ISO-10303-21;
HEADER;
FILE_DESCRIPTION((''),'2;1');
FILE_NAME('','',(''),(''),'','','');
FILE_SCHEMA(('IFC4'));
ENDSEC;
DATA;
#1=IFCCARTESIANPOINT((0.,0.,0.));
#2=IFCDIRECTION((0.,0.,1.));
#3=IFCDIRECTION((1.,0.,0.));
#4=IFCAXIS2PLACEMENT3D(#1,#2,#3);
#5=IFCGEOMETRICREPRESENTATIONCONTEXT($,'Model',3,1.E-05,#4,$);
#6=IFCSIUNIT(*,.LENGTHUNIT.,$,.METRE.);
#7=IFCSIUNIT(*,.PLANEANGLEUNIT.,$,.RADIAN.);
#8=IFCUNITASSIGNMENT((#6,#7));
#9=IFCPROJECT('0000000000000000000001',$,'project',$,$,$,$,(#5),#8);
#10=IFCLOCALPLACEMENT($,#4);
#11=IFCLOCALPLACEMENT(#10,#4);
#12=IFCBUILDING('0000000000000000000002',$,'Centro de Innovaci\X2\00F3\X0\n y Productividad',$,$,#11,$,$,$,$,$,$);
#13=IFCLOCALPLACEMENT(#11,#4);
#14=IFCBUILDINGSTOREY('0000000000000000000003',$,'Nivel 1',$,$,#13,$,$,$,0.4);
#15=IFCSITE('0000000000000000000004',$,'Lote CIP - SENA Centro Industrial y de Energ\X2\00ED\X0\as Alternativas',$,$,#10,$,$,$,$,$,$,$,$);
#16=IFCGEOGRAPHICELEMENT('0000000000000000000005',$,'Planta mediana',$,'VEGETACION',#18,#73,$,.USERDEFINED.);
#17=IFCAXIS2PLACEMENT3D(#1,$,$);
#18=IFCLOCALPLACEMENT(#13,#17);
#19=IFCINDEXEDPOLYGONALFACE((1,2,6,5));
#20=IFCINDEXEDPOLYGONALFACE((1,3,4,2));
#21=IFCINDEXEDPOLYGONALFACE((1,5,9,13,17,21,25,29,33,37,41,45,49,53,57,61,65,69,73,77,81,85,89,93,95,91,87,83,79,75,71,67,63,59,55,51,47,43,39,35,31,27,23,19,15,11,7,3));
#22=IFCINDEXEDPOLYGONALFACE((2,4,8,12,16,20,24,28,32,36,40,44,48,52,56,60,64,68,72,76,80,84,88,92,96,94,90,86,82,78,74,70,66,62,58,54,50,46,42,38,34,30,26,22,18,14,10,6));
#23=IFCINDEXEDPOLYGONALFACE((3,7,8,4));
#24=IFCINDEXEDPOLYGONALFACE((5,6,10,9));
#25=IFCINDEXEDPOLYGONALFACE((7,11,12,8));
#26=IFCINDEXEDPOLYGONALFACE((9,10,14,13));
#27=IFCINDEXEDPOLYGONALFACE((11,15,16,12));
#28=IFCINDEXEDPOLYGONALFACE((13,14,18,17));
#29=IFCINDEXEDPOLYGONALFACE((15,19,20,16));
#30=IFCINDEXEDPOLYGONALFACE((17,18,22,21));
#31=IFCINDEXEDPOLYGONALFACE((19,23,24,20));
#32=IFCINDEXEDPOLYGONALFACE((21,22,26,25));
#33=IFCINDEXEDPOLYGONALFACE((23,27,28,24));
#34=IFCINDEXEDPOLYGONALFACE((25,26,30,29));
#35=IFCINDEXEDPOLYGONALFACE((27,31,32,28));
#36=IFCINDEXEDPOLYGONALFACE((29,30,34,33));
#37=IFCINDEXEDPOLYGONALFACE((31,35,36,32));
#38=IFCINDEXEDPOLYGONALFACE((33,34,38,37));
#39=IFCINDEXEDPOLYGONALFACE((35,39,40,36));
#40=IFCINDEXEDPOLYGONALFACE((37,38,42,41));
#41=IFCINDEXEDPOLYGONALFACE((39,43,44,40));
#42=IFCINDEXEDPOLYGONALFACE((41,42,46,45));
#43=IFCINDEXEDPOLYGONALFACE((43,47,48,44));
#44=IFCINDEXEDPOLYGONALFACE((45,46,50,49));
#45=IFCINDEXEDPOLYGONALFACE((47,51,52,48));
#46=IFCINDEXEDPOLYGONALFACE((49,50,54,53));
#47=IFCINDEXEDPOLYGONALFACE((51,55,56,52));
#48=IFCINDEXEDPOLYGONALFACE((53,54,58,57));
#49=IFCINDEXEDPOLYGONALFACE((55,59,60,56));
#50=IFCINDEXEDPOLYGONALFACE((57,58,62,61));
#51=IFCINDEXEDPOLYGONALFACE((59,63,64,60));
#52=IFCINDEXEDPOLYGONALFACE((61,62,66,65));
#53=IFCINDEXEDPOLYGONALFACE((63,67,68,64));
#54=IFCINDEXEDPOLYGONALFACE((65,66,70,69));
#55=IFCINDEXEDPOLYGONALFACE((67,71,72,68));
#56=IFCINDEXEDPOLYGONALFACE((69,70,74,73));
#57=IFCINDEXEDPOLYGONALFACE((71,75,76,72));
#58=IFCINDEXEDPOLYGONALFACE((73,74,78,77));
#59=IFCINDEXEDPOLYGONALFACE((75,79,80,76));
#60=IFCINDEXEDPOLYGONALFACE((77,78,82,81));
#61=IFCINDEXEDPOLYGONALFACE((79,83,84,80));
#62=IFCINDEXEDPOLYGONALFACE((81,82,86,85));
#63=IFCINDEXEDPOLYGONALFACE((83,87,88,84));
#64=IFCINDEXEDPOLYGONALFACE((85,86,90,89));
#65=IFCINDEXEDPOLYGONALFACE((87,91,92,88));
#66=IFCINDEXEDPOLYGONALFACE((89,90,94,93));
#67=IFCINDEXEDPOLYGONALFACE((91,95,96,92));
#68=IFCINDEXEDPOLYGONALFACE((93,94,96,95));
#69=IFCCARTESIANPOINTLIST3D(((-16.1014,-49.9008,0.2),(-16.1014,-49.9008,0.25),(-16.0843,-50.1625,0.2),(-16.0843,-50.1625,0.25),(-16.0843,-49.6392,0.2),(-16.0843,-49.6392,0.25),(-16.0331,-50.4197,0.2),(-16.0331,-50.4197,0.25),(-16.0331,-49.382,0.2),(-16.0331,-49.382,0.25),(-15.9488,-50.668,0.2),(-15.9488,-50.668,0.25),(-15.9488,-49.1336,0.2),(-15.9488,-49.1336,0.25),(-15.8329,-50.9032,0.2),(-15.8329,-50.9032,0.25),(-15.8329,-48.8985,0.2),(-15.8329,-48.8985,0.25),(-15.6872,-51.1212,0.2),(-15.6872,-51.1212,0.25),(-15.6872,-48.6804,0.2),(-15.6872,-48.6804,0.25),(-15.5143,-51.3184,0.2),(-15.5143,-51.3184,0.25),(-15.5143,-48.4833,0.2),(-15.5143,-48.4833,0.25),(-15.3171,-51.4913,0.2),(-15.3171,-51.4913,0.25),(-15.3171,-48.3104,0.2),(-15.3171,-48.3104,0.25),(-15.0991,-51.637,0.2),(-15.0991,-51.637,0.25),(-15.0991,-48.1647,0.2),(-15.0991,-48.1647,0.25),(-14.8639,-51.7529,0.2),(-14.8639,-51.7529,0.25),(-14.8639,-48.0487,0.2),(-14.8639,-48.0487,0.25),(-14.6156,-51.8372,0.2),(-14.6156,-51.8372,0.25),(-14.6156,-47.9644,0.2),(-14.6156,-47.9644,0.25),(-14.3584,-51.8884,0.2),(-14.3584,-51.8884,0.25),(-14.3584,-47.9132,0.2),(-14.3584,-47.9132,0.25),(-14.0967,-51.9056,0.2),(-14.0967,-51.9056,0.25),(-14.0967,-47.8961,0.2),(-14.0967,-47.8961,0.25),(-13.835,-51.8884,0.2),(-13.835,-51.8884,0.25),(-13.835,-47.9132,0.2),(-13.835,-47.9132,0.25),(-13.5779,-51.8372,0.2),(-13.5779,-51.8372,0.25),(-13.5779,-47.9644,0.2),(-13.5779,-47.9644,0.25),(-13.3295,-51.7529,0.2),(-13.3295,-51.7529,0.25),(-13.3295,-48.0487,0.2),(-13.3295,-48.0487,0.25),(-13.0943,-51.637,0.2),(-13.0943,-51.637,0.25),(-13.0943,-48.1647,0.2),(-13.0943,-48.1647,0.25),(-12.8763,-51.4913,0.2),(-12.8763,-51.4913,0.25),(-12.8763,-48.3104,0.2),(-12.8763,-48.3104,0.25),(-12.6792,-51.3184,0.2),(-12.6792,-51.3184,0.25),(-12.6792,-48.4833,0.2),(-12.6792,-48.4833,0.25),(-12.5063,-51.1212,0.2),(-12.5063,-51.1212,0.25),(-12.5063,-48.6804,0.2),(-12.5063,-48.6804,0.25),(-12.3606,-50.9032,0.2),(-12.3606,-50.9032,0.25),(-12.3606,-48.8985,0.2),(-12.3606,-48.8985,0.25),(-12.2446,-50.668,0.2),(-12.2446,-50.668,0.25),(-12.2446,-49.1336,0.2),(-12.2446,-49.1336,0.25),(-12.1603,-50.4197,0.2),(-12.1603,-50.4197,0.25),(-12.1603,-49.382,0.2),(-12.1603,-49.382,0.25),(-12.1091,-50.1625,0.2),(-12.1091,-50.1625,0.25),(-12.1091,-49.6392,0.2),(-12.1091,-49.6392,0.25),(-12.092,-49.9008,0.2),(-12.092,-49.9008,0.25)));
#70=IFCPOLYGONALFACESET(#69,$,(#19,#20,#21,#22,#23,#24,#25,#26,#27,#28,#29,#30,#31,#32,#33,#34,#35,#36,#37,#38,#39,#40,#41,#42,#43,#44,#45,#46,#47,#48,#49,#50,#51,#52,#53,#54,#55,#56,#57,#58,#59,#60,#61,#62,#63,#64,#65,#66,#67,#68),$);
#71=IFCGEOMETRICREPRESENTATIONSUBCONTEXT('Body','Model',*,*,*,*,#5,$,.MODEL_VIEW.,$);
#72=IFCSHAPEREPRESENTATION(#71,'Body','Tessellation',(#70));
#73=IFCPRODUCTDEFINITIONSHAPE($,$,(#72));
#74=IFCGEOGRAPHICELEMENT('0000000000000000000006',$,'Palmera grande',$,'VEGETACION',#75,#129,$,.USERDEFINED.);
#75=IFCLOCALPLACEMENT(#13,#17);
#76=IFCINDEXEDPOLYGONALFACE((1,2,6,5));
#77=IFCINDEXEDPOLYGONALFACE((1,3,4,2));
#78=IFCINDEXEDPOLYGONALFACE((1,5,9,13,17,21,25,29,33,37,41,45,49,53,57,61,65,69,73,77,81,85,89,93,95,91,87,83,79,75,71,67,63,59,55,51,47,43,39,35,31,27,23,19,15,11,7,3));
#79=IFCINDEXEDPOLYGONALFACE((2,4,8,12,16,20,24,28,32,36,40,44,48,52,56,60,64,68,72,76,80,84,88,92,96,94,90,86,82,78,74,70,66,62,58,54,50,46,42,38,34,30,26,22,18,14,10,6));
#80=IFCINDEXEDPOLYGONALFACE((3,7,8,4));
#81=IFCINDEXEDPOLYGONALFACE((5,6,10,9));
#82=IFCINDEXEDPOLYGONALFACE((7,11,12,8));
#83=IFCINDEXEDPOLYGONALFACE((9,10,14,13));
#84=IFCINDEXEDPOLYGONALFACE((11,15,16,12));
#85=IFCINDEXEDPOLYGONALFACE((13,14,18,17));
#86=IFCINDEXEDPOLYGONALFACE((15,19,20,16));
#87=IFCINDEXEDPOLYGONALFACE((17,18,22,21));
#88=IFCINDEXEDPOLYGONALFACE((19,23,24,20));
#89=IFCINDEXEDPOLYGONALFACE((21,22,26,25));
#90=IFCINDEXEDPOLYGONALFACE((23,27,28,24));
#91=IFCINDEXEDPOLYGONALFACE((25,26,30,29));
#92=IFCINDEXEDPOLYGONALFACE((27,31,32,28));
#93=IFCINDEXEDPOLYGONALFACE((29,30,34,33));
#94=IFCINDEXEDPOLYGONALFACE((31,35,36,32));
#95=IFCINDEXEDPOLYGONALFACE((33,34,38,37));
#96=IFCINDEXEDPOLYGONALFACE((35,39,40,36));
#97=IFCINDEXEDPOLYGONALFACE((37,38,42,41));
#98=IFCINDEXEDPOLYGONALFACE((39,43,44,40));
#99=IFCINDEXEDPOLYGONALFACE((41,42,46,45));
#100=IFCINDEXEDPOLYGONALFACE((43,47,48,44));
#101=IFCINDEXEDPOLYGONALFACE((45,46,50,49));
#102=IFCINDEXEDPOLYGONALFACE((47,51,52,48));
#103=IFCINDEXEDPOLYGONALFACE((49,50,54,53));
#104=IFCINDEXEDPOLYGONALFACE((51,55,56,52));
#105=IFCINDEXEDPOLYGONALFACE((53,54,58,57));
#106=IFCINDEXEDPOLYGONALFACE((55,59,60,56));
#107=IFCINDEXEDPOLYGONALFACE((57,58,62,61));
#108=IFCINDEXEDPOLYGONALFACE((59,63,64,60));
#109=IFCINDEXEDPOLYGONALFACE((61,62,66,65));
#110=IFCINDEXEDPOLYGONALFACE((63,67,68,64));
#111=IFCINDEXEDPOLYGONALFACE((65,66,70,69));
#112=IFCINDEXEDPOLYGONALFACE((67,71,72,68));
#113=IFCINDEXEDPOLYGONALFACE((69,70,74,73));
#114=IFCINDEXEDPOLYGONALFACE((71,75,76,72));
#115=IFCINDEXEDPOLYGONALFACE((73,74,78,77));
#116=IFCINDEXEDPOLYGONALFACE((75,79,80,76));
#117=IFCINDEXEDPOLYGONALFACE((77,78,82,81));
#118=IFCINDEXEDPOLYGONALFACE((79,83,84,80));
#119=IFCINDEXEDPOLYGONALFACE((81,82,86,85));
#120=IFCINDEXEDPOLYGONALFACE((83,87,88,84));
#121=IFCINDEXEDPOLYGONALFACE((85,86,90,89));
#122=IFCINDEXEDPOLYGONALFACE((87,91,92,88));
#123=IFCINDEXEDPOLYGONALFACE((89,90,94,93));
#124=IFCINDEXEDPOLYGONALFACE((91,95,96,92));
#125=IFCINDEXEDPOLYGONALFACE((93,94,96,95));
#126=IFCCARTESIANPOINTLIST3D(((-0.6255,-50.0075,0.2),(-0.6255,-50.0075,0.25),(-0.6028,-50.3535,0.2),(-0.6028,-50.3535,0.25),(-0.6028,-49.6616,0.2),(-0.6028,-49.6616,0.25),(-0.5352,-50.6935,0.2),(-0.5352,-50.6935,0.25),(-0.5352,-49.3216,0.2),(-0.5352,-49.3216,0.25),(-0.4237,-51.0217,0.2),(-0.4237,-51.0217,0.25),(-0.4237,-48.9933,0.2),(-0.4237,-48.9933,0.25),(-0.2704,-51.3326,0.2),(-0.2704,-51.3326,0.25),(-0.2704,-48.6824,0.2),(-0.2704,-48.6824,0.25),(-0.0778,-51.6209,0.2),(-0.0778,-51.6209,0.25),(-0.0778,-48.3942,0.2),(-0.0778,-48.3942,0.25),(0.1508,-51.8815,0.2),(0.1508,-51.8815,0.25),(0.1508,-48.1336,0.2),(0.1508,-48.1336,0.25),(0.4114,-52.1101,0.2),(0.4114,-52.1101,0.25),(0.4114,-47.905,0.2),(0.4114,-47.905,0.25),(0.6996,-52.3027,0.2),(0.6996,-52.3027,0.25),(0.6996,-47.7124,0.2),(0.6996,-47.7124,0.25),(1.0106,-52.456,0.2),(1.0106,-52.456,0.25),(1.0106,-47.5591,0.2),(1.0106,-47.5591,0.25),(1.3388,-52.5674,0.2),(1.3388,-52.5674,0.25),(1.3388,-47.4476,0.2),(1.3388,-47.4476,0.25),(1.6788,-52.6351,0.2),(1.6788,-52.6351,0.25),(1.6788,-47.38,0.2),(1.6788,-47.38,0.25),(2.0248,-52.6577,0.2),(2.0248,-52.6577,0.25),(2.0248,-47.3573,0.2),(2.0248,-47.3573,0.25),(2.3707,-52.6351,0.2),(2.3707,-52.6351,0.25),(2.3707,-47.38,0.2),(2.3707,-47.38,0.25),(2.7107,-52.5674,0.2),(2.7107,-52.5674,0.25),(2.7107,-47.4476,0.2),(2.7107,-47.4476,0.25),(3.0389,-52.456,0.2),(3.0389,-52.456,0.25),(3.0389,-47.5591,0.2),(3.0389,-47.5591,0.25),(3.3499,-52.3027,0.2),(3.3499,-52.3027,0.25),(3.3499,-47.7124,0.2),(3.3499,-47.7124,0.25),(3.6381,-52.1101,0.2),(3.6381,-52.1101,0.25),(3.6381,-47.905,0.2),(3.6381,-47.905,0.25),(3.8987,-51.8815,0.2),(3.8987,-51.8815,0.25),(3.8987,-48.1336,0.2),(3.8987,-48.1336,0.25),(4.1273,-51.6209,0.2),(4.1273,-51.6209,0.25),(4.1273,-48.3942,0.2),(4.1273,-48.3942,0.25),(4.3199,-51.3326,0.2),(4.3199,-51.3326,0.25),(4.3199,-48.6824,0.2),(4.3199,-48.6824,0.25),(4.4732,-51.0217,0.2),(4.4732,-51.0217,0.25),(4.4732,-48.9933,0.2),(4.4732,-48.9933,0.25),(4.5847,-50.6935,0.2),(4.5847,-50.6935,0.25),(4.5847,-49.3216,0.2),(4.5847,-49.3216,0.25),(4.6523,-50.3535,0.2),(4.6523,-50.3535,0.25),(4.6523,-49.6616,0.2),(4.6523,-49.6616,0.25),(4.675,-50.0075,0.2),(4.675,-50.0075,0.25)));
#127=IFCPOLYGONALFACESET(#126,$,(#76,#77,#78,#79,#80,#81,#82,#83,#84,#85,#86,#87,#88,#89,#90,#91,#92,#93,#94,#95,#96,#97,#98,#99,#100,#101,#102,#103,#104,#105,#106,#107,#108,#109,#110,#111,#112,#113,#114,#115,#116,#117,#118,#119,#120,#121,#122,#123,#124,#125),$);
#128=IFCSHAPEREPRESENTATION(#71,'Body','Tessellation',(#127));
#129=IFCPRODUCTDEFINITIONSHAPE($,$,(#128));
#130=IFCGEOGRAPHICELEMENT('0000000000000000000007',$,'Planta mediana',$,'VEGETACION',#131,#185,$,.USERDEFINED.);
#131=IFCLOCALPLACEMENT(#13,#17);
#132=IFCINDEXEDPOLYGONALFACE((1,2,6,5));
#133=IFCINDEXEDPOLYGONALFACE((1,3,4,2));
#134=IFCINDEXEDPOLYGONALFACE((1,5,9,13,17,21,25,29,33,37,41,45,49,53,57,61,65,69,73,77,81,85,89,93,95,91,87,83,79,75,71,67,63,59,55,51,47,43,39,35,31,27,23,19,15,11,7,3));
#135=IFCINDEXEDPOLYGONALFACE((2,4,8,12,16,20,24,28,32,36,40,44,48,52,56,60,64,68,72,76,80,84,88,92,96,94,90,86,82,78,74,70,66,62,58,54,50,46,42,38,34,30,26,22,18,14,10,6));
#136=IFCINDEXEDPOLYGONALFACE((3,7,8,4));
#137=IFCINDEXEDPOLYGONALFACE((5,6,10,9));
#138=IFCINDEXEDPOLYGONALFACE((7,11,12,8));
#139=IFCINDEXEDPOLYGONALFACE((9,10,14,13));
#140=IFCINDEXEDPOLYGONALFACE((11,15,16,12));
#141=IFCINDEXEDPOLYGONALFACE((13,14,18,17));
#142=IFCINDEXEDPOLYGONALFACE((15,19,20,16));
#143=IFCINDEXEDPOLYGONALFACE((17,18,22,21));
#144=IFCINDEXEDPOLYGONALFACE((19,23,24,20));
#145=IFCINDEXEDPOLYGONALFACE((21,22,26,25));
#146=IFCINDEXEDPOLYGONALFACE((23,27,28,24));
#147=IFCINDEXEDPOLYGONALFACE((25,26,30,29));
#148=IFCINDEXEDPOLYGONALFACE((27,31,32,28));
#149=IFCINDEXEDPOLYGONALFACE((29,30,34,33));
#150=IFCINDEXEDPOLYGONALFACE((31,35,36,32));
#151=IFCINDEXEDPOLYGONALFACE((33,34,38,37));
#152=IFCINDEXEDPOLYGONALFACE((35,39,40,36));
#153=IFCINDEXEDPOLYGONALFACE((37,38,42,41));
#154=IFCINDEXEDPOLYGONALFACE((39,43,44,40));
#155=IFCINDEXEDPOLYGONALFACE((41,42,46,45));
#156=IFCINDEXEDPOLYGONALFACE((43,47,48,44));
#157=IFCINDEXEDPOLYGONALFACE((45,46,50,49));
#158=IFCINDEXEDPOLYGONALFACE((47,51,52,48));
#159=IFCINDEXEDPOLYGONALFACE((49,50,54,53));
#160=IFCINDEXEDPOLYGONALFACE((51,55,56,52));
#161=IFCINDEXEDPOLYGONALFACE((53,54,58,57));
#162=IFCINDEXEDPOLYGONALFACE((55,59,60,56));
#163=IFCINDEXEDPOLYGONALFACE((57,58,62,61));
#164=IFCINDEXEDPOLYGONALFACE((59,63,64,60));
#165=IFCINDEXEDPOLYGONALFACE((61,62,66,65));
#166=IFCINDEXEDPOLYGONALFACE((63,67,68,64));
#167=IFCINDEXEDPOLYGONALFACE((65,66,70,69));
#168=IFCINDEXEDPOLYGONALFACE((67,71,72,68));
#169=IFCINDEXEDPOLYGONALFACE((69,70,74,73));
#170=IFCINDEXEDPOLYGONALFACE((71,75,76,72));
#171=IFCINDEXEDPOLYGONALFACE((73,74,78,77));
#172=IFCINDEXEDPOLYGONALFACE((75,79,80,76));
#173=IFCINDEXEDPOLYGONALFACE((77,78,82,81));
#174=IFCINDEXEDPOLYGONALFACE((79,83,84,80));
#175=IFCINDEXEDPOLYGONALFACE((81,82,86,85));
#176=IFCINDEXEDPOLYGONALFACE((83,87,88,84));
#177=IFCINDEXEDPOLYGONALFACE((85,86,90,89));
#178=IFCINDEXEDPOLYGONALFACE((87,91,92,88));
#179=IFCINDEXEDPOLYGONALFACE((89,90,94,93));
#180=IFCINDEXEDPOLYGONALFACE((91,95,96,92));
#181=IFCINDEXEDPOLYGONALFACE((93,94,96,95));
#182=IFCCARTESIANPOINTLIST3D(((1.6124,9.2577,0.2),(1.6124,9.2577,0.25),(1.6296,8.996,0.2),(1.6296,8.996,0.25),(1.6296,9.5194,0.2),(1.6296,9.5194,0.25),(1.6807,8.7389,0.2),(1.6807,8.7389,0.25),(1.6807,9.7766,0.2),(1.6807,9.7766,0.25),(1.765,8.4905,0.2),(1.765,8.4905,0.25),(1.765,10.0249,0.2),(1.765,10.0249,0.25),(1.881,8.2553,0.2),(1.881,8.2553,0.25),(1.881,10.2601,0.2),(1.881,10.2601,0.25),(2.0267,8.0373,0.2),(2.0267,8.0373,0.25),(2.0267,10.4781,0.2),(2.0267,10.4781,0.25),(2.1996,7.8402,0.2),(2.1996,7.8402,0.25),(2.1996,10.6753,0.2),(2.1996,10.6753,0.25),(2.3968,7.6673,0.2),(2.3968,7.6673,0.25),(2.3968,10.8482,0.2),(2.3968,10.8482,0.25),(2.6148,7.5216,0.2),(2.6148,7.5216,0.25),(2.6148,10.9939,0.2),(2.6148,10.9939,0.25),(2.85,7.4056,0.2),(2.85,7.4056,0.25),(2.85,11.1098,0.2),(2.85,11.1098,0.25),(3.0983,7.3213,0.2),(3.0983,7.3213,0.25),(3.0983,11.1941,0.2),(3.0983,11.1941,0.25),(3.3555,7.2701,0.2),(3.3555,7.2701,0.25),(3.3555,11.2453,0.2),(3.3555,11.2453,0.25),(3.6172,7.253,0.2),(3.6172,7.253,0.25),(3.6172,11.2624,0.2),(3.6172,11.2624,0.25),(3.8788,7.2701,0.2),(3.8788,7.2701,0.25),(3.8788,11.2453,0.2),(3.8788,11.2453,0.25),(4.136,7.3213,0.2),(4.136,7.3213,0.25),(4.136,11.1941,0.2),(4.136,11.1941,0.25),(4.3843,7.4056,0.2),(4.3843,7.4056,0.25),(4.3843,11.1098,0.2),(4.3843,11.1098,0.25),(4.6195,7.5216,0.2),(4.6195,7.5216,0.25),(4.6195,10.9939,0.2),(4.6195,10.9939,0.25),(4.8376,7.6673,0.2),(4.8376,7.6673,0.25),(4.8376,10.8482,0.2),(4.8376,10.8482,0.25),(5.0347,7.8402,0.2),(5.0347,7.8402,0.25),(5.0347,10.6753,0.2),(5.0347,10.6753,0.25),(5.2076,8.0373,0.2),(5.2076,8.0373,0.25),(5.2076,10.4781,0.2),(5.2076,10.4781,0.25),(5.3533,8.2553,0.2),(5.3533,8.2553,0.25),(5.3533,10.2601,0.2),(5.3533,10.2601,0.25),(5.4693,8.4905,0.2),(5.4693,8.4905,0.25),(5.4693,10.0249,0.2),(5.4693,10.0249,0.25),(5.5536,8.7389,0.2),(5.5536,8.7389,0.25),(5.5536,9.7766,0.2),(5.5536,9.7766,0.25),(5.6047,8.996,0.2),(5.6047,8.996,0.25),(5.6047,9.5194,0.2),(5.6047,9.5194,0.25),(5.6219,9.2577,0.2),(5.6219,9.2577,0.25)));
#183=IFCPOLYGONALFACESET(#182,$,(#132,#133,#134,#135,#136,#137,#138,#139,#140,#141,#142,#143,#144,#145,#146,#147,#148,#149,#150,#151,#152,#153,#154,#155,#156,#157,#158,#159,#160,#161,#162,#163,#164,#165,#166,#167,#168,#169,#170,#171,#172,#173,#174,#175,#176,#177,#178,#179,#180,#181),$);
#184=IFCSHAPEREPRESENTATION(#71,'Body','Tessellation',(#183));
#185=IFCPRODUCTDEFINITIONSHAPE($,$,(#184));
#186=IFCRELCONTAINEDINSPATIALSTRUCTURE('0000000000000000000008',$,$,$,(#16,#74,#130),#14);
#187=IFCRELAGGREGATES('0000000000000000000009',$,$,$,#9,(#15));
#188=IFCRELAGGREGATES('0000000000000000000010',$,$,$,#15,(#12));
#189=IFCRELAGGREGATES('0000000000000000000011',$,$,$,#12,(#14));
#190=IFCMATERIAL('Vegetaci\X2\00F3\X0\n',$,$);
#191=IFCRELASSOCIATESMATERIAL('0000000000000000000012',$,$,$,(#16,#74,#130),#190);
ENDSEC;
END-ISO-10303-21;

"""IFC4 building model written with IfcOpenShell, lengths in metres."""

from ifc_helpers import new_model, si_unit, frame, origin_with_axes, place, context, subcontext, project, spatial, polyline, outline, extrude, material, element, save


model = new_model("IFC4")

# Units and contexts
model_context = context("Model", 3, precision=1e-05, world=origin_with_axes())
body_context = subcontext(model_context, "Body", "Model", "MODEL_VIEW")
ifc_project = project(units=[si_unit("LENGTHUNIT", "METRE"), si_unit("PLANEANGLEUNIT", "RADIAN")], contexts=[model_context])

# Site, building, storey
site_placement = place(None, origin_with_axes())
site = spatial("IfcSite", under=ifc_project, at=site_placement, Name="Lote CIP - SENA Centro Industrial y de Energías Alternativas")
building_placement = place(site_placement, origin_with_axes())
building = spatial("IfcBuilding", under=site, at=building_placement, Name="Centro de Innovación y Productividad")
storey_placement = place(building_placement, origin_with_axes())
storey = spatial("IfcBuildingStorey", under=building, at=storey_placement, Name="Nivel 1", Elevation=0.4)

# Geographic elements
ifc_material_1 = material(Name="Vegetación")
geographic_element_1_placement = place(storey_placement, origin_with_axes())
element("IfcGeographicElement", 1, at=geographic_element_1_placement, inside=storey, material=ifc_material_1, Name="Planta mediana", ObjectType="VEGETACION", PredefinedType="USERDEFINED", context=body_context, shape_type="SweptSolid", body=[
    extrude(outline(polyline([(-12.092, -49.9008), (-12.1091, -50.1625), (-12.1603, -50.4197), (-12.2446, -50.668), (-12.3606, -50.9032), (-12.5063, -51.1212), (-12.6792, -51.3184), (-12.8763, -51.4913), (-13.0943, -51.637), (-13.3295, -51.7529), (-13.5779, -51.8372), (-13.835, -51.8884), (-14.0967, -51.9056), (-14.3584, -51.8884), (-14.6156, -51.8372), (-14.8639, -51.7529), (-15.0991, -51.637), (-15.3171, -51.4913), (-15.5143, -51.3184), (-15.6872, -51.1212), (-15.8329, -50.9032), (-15.9488, -50.668), (-16.0331, -50.4197), (-16.0843, -50.1625), (-16.1014, -49.9008), (-16.0843, -49.6392), (-16.0331, -49.382), (-15.9488, -49.1336), (-15.8329, -48.8985), (-15.6872, -48.6804), (-15.5143, -48.4833), (-15.3171, -48.3104), (-15.0991, -48.1647), (-14.8639, -48.0487), (-14.6156, -47.9644), (-14.3584, -47.9132), (-14.0967, -47.8961), (-13.835, -47.9132), (-13.5779, -47.9644), (-13.3295, -48.0487), (-13.0943, -48.1647), (-12.8763, -48.3104), (-12.6792, -48.4833), (-12.5063, -48.6804), (-12.3606, -48.8985), (-12.2446, -49.1336), (-12.1603, -49.382), (-12.1091, -49.6392), (-12.092, -49.9008)])), frame((0.0, 0.0, 0.2)), (0.0, 0.0, 1.0), 0.05),
])
geographic_element_2_placement = place(storey_placement, origin_with_axes())
element("IfcGeographicElement", 2, at=geographic_element_2_placement, inside=storey, material=ifc_material_1, Name="Palmera grande", ObjectType="VEGETACION", PredefinedType="USERDEFINED", context=body_context, shape_type="SweptSolid", body=[
    extrude(outline(polyline([(4.675, -50.0075), (4.6523, -50.3535), (4.5847, -50.6935), (4.4732, -51.0217), (4.3199, -51.3326), (4.1273, -51.6209), (3.8987, -51.8815), (3.6381, -52.1101), (3.3499, -52.3027), (3.0389, -52.456), (2.7107, -52.5674), (2.3707, -52.6351), (2.0248, -52.6577), (1.6788, -52.6351), (1.3388, -52.5674), (1.0106, -52.456), (0.6996, -52.3027), (0.4114, -52.1101), (0.1508, -51.8815), (-0.0778, -51.6209), (-0.2704, -51.3326), (-0.4237, -51.0217), (-0.5352, -50.6935), (-0.6028, -50.3535), (-0.6255, -50.0075), (-0.6028, -49.6616), (-0.5352, -49.3216), (-0.4237, -48.9933), (-0.2704, -48.6824), (-0.0778, -48.3942), (0.1508, -48.1336), (0.4114, -47.905), (0.6996, -47.7124), (1.0106, -47.5591), (1.3388, -47.4476), (1.6788, -47.38), (2.0248, -47.3573), (2.3707, -47.38), (2.7107, -47.4476), (3.0389, -47.5591), (3.3499, -47.7124), (3.6381, -47.905), (3.8987, -48.1336), (4.1273, -48.3942), (4.3199, -48.6824), (4.4732, -48.9933), (4.5847, -49.3216), (4.6523, -49.6616), (4.675, -50.0075)])), frame((0.0, 0.0, 0.2)), (0.0, 0.0, 1.0), 0.05),
])
geographic_element_3_placement = place(storey_placement, origin_with_axes())
element("IfcGeographicElement", 3, at=geographic_element_3_placement, inside=storey, material=ifc_material_1, Name="Planta mediana", ObjectType="VEGETACION", PredefinedType="USERDEFINED", context=body_context, shape_type="SweptSolid", body=[
    extrude(outline(polyline([(5.6219, 9.2577), (5.6047, 8.996), (5.5536, 8.7389), (5.4693, 8.4905), (5.3533, 8.2553), (5.2076, 8.0373), (5.0347, 7.8402), (4.8376, 7.6673), (4.6195, 7.5216), (4.3843, 7.4056), (4.136, 7.3213), (3.8788, 7.2701), (3.6172, 7.253), (3.3555, 7.2701), (3.0983, 7.3213), (2.85, 7.4056), (2.6148, 7.5216), (2.3968, 7.6673), (2.1996, 7.8402), (2.0267, 8.0373), (1.881, 8.2553), (1.765, 8.4905), (1.6807, 8.7389), (1.6296, 8.996), (1.6124, 9.2577), (1.6296, 9.5194), (1.6807, 9.7766), (1.765, 10.0249), (1.881, 10.2601), (2.0267, 10.4781), (2.1996, 10.6753), (2.3968, 10.8482), (2.6148, 10.9939), (2.85, 11.1098), (3.0983, 11.1941), (3.3555, 11.2453), (3.6172, 11.2624), (3.8788, 11.2453), (4.136, 11.1941), (4.3843, 11.1098), (4.6195, 10.9939), (4.8376, 10.8482), (5.0347, 10.6753), (5.2076, 10.4781), (5.3533, 10.2601), (5.4693, 10.0249), (5.5536, 9.7766), (5.6047, 9.5194), (5.6219, 9.2577)])), frame((0.0, 0.0, 0.2)), (0.0, 0.0, 1.0), 0.05),
])

save(model, "model.ifc")
